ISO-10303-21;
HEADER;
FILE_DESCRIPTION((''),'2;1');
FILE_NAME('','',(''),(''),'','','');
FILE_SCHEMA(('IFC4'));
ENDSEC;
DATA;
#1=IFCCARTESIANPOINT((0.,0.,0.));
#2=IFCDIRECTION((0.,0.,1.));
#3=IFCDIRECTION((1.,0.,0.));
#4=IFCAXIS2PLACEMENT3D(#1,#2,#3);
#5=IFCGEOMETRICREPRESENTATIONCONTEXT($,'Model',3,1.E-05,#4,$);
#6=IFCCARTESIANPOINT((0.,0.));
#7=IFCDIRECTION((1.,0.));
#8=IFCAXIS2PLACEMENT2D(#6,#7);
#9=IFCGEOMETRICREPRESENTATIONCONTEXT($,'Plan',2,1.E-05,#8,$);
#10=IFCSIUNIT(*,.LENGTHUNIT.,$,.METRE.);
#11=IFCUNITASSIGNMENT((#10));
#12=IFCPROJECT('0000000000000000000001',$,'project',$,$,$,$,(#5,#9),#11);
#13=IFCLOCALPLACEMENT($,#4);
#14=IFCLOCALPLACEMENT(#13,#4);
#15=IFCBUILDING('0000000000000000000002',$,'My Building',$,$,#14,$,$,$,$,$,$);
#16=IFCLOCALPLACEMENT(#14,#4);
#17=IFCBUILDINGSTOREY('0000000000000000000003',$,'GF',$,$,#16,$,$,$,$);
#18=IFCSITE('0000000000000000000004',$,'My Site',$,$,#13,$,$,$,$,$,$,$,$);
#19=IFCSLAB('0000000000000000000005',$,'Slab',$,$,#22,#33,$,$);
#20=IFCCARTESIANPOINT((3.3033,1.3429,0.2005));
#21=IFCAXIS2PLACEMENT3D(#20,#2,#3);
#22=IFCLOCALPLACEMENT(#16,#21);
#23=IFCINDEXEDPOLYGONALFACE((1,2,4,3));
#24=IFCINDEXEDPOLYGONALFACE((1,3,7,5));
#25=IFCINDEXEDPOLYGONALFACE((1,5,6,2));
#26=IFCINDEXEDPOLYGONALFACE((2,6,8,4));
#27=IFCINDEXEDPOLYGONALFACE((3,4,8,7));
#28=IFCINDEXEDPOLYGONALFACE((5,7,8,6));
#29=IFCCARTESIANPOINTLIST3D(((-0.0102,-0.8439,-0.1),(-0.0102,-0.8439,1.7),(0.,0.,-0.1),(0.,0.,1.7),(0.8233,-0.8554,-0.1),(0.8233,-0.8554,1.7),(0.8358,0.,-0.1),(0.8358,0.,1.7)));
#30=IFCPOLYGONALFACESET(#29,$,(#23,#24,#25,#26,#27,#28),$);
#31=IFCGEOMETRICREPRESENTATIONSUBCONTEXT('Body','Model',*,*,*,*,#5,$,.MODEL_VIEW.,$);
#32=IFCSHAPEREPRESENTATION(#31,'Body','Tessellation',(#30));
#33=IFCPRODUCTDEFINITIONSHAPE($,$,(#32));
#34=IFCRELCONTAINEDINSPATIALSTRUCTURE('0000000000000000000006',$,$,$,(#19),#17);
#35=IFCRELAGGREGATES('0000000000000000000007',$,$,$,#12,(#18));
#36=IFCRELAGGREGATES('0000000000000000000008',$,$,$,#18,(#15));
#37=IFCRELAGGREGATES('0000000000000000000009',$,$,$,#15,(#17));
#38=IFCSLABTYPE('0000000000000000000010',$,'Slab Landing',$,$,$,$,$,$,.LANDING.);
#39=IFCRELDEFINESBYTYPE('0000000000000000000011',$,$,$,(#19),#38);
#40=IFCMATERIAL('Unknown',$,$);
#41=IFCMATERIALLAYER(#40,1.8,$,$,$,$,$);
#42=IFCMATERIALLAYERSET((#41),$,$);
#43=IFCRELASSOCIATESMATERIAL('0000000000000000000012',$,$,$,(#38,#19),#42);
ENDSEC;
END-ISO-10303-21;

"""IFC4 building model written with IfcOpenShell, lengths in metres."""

from ifc_helpers import new_model, si_unit, frame, origin_with_axes, origin_2d_with_axis, place, context, subcontext, project, spatial, indexed_curve, outline, extrude, material, layer, layer_set, layer_usage, type_object, element, save


model = new_model("IFC4")

# Units and contexts
model_context = context("Model", 3, precision=1e-05, world=origin_with_axes())
plan_context = context("Plan", 2, precision=1e-05, world=origin_2d_with_axis())
body_context_1 = subcontext(model_context, "Body", "Model", "MODEL_VIEW")
ifc_project = project(units=[si_unit("LENGTHUNIT", "METRE")], contexts=[model_context, plan_context])

# Site, building, storey
site_placement = place(None, origin_with_axes())
site = spatial("IfcSite", under=ifc_project, at=site_placement, Name="My Site")
building_placement = place(site_placement, origin_with_axes())
building = spatial("IfcBuilding", under=site, at=building_placement, Name="My Building")
storey_placement = place(building_placement, origin_with_axes())
storey = spatial("IfcBuildingStorey", under=building, at=storey_placement, Name="GF")

# Shared definitions
ifc_material = material(Name="Unknown")

# Slab
ifc_layer_1 = layer(ifc_material, 1.8)
ifc_layer_set_1 = layer_set([ifc_layer_1])
ifc_layer_usage_1 = layer_usage(ifc_layer_set_1, "AXIS3", "POSITIVE", -0.1)
slab_type_1 = type_object("IfcSlabType", Name="Slab Landing", PredefinedType="LANDING", material=ifc_layer_set_1)
slab_1_placement = place(storey_placement, frame((3.3033, 1.3429, 0.2005), z_axis=(0.0, 0.0, 1.0), x_axis=(1.0, 0.0, 0.0)))
element("IfcSlab", 1, at=slab_1_placement, inside=storey, type_object=slab_type_1, material=ifc_layer_usage_1, Name="Slab", context=body_context_1, shape_type="SweptSolid", body=[
    extrude(outline(indexed_curve([(0.0, 0.0), (-0.0102, -0.8439), (0.8233, -0.8554), (0.8358, 0.0), (0.0, 0.0)])), frame((0.0, 0.0, -0.1), z_axis=(0.0, 0.0, 1.0), x_axis=(1.0, 0.0, 0.0)), (0.0, 0.0, 1.0), 1.8),
])

save(model, "model.ifc")
